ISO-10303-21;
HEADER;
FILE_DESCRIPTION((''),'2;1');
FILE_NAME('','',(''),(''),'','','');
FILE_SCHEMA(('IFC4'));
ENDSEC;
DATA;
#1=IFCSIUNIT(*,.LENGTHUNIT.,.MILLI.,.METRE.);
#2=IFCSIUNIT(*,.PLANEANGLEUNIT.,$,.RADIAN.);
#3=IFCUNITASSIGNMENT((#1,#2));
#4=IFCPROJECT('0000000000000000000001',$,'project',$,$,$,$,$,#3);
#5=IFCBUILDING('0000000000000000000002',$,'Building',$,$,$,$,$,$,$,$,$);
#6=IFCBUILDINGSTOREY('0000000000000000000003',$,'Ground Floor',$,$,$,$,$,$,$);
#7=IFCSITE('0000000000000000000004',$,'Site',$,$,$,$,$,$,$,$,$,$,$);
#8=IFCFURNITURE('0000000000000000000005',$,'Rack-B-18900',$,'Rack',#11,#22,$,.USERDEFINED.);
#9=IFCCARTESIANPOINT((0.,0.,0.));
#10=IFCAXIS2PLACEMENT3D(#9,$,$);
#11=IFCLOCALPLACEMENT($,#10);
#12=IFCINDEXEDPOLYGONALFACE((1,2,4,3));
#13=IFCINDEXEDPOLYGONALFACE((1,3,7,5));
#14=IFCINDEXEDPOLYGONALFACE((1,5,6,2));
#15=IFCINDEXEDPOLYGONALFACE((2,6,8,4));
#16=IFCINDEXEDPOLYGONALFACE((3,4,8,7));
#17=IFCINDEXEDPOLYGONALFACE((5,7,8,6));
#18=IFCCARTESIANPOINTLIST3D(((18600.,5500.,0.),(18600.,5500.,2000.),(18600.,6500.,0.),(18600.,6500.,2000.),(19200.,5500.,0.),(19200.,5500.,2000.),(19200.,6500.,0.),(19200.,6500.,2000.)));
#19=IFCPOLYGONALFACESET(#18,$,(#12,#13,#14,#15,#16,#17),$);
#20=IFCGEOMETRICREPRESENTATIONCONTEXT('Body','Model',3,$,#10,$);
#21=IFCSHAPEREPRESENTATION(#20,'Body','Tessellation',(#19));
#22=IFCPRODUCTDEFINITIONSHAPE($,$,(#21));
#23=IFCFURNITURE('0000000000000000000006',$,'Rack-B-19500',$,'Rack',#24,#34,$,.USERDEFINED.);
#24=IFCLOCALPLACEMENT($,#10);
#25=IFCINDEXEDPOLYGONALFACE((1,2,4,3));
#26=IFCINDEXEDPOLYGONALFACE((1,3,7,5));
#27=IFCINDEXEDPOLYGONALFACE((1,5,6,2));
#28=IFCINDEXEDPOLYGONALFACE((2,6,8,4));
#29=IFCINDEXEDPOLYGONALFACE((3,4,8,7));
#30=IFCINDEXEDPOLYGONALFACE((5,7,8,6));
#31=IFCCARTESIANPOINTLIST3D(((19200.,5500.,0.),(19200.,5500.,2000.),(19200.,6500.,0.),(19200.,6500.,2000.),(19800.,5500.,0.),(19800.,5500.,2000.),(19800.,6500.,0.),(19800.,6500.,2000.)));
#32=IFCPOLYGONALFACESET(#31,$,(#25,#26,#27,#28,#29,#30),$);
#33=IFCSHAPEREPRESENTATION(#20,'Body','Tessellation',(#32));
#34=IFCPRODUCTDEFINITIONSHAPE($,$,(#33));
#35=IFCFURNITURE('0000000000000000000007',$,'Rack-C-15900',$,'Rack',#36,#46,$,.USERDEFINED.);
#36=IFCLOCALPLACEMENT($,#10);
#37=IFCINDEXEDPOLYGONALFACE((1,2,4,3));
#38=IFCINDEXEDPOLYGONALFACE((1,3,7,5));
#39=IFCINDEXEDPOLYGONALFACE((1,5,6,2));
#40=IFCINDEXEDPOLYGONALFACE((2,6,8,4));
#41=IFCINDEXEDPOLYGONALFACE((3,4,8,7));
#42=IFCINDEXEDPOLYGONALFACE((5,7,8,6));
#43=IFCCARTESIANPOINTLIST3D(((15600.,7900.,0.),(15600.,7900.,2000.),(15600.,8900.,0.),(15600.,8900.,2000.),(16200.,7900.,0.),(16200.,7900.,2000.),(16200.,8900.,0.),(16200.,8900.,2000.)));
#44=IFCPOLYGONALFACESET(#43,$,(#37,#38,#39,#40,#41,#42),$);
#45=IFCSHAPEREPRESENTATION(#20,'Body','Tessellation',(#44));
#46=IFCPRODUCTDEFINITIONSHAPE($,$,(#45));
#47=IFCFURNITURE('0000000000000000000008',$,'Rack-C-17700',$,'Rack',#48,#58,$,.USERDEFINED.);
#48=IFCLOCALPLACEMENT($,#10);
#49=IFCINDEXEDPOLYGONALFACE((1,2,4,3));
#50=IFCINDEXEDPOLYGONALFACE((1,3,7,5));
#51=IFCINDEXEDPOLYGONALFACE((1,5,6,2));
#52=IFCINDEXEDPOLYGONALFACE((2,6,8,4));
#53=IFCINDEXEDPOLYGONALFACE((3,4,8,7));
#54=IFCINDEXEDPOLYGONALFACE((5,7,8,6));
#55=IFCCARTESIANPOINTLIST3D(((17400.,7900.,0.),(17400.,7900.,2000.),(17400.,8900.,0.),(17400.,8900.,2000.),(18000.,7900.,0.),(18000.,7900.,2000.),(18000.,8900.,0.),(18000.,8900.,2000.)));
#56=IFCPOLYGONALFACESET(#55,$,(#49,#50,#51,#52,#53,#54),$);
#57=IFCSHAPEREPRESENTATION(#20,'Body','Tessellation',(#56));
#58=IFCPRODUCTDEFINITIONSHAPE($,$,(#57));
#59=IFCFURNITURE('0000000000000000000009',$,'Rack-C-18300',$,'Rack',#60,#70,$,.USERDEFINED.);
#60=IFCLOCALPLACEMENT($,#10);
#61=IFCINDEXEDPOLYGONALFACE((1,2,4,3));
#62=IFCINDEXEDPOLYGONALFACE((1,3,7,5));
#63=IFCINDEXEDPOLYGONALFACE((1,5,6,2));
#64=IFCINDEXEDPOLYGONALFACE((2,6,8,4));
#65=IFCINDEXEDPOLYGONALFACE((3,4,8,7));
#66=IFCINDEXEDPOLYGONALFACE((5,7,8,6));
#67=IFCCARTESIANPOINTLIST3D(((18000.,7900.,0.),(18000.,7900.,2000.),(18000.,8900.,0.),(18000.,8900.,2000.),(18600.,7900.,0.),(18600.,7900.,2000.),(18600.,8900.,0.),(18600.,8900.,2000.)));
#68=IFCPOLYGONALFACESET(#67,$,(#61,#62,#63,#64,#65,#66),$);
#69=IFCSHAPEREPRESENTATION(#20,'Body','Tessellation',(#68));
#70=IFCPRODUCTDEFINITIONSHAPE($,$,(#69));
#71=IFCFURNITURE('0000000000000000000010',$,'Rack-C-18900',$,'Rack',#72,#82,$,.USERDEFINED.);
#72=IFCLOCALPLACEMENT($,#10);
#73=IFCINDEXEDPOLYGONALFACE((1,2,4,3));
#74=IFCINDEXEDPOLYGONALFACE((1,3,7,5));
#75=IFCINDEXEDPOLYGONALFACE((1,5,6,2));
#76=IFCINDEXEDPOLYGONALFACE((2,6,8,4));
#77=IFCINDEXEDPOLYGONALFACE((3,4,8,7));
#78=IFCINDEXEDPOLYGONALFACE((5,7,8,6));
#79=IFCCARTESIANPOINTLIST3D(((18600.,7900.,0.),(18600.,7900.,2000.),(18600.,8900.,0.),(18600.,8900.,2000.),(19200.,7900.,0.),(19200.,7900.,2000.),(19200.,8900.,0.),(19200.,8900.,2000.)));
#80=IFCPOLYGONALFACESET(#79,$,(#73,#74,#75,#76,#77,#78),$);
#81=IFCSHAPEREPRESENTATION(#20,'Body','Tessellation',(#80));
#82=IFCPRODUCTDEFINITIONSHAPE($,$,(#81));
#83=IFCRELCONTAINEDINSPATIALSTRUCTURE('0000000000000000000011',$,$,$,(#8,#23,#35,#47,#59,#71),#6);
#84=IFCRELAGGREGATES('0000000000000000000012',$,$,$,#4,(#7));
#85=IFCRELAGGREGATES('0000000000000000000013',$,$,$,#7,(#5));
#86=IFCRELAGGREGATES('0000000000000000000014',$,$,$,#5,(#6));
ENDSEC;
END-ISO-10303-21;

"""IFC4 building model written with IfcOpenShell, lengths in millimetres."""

from ifc_helpers import new_model, si_unit, frame, origin, place, context, project, spatial, rectangle, extrude, element, save


model = new_model("IFC4")

# Units and contexts
model_context = context("Model", 3, world=origin(), identifier="Body")
ifc_project = project(units=[si_unit("LENGTHUNIT", "METRE", prefix="MILLI"), si_unit("PLANEANGLEUNIT", "RADIAN")])

# Site, building, storey
site = spatial("IfcSite", under=ifc_project, Name="Site")
building = spatial("IfcBuilding", under=site, Name="Building")
storey = spatial("IfcBuildingStorey", under=building, Name="Ground Floor")

# Furniture
for number, where, z_axis, x_axis, name in (
    (1, (18900.0, 6000.0, 0.0), (0.0, 0.0, 1.0), (1.0, 0.0, 0.0), "Rack-B-18900"),
    (2, (19500.0, 6000.0, 0.0), (0.0, 0.0, 1.0), (1.0, 0.0, 0.0), "Rack-B-19500"),
    (3, (15900.0, 8400.0, 0.0), (0.0, 0.0, 1.0), (1.0, 0.0, 0.0), "Rack-C-15900"),
    (4, (17700.0, 8400.0, 0.0), (0.0, 0.0, 1.0), (1.0, 0.0, 0.0), "Rack-C-17700"),
    (5, (18300.0, 8400.0, 0.0), (0.0, 0.0, 1.0), (1.0, 0.0, 0.0), "Rack-C-18300"),
    (6, (18900.0, 8400.0, 0.0), (0.0, 0.0, 1.0), (1.0, 0.0, 0.0), "Rack-C-18900"),
):
    element("IfcFurniture", number, at=place(None, frame(where, z_axis=z_axis, x_axis=x_axis)), inside=storey, Name=name, ObjectType="Rack", PredefinedType="USERDEFINED", context=model_context, shape_type="SweptSolid", body=[
        extrude(rectangle(XDim=600.0, YDim=1000.0), origin(), (0.0, 0.0, 1.0), 2000.0),
    ])

save(model, "model.ifc")
